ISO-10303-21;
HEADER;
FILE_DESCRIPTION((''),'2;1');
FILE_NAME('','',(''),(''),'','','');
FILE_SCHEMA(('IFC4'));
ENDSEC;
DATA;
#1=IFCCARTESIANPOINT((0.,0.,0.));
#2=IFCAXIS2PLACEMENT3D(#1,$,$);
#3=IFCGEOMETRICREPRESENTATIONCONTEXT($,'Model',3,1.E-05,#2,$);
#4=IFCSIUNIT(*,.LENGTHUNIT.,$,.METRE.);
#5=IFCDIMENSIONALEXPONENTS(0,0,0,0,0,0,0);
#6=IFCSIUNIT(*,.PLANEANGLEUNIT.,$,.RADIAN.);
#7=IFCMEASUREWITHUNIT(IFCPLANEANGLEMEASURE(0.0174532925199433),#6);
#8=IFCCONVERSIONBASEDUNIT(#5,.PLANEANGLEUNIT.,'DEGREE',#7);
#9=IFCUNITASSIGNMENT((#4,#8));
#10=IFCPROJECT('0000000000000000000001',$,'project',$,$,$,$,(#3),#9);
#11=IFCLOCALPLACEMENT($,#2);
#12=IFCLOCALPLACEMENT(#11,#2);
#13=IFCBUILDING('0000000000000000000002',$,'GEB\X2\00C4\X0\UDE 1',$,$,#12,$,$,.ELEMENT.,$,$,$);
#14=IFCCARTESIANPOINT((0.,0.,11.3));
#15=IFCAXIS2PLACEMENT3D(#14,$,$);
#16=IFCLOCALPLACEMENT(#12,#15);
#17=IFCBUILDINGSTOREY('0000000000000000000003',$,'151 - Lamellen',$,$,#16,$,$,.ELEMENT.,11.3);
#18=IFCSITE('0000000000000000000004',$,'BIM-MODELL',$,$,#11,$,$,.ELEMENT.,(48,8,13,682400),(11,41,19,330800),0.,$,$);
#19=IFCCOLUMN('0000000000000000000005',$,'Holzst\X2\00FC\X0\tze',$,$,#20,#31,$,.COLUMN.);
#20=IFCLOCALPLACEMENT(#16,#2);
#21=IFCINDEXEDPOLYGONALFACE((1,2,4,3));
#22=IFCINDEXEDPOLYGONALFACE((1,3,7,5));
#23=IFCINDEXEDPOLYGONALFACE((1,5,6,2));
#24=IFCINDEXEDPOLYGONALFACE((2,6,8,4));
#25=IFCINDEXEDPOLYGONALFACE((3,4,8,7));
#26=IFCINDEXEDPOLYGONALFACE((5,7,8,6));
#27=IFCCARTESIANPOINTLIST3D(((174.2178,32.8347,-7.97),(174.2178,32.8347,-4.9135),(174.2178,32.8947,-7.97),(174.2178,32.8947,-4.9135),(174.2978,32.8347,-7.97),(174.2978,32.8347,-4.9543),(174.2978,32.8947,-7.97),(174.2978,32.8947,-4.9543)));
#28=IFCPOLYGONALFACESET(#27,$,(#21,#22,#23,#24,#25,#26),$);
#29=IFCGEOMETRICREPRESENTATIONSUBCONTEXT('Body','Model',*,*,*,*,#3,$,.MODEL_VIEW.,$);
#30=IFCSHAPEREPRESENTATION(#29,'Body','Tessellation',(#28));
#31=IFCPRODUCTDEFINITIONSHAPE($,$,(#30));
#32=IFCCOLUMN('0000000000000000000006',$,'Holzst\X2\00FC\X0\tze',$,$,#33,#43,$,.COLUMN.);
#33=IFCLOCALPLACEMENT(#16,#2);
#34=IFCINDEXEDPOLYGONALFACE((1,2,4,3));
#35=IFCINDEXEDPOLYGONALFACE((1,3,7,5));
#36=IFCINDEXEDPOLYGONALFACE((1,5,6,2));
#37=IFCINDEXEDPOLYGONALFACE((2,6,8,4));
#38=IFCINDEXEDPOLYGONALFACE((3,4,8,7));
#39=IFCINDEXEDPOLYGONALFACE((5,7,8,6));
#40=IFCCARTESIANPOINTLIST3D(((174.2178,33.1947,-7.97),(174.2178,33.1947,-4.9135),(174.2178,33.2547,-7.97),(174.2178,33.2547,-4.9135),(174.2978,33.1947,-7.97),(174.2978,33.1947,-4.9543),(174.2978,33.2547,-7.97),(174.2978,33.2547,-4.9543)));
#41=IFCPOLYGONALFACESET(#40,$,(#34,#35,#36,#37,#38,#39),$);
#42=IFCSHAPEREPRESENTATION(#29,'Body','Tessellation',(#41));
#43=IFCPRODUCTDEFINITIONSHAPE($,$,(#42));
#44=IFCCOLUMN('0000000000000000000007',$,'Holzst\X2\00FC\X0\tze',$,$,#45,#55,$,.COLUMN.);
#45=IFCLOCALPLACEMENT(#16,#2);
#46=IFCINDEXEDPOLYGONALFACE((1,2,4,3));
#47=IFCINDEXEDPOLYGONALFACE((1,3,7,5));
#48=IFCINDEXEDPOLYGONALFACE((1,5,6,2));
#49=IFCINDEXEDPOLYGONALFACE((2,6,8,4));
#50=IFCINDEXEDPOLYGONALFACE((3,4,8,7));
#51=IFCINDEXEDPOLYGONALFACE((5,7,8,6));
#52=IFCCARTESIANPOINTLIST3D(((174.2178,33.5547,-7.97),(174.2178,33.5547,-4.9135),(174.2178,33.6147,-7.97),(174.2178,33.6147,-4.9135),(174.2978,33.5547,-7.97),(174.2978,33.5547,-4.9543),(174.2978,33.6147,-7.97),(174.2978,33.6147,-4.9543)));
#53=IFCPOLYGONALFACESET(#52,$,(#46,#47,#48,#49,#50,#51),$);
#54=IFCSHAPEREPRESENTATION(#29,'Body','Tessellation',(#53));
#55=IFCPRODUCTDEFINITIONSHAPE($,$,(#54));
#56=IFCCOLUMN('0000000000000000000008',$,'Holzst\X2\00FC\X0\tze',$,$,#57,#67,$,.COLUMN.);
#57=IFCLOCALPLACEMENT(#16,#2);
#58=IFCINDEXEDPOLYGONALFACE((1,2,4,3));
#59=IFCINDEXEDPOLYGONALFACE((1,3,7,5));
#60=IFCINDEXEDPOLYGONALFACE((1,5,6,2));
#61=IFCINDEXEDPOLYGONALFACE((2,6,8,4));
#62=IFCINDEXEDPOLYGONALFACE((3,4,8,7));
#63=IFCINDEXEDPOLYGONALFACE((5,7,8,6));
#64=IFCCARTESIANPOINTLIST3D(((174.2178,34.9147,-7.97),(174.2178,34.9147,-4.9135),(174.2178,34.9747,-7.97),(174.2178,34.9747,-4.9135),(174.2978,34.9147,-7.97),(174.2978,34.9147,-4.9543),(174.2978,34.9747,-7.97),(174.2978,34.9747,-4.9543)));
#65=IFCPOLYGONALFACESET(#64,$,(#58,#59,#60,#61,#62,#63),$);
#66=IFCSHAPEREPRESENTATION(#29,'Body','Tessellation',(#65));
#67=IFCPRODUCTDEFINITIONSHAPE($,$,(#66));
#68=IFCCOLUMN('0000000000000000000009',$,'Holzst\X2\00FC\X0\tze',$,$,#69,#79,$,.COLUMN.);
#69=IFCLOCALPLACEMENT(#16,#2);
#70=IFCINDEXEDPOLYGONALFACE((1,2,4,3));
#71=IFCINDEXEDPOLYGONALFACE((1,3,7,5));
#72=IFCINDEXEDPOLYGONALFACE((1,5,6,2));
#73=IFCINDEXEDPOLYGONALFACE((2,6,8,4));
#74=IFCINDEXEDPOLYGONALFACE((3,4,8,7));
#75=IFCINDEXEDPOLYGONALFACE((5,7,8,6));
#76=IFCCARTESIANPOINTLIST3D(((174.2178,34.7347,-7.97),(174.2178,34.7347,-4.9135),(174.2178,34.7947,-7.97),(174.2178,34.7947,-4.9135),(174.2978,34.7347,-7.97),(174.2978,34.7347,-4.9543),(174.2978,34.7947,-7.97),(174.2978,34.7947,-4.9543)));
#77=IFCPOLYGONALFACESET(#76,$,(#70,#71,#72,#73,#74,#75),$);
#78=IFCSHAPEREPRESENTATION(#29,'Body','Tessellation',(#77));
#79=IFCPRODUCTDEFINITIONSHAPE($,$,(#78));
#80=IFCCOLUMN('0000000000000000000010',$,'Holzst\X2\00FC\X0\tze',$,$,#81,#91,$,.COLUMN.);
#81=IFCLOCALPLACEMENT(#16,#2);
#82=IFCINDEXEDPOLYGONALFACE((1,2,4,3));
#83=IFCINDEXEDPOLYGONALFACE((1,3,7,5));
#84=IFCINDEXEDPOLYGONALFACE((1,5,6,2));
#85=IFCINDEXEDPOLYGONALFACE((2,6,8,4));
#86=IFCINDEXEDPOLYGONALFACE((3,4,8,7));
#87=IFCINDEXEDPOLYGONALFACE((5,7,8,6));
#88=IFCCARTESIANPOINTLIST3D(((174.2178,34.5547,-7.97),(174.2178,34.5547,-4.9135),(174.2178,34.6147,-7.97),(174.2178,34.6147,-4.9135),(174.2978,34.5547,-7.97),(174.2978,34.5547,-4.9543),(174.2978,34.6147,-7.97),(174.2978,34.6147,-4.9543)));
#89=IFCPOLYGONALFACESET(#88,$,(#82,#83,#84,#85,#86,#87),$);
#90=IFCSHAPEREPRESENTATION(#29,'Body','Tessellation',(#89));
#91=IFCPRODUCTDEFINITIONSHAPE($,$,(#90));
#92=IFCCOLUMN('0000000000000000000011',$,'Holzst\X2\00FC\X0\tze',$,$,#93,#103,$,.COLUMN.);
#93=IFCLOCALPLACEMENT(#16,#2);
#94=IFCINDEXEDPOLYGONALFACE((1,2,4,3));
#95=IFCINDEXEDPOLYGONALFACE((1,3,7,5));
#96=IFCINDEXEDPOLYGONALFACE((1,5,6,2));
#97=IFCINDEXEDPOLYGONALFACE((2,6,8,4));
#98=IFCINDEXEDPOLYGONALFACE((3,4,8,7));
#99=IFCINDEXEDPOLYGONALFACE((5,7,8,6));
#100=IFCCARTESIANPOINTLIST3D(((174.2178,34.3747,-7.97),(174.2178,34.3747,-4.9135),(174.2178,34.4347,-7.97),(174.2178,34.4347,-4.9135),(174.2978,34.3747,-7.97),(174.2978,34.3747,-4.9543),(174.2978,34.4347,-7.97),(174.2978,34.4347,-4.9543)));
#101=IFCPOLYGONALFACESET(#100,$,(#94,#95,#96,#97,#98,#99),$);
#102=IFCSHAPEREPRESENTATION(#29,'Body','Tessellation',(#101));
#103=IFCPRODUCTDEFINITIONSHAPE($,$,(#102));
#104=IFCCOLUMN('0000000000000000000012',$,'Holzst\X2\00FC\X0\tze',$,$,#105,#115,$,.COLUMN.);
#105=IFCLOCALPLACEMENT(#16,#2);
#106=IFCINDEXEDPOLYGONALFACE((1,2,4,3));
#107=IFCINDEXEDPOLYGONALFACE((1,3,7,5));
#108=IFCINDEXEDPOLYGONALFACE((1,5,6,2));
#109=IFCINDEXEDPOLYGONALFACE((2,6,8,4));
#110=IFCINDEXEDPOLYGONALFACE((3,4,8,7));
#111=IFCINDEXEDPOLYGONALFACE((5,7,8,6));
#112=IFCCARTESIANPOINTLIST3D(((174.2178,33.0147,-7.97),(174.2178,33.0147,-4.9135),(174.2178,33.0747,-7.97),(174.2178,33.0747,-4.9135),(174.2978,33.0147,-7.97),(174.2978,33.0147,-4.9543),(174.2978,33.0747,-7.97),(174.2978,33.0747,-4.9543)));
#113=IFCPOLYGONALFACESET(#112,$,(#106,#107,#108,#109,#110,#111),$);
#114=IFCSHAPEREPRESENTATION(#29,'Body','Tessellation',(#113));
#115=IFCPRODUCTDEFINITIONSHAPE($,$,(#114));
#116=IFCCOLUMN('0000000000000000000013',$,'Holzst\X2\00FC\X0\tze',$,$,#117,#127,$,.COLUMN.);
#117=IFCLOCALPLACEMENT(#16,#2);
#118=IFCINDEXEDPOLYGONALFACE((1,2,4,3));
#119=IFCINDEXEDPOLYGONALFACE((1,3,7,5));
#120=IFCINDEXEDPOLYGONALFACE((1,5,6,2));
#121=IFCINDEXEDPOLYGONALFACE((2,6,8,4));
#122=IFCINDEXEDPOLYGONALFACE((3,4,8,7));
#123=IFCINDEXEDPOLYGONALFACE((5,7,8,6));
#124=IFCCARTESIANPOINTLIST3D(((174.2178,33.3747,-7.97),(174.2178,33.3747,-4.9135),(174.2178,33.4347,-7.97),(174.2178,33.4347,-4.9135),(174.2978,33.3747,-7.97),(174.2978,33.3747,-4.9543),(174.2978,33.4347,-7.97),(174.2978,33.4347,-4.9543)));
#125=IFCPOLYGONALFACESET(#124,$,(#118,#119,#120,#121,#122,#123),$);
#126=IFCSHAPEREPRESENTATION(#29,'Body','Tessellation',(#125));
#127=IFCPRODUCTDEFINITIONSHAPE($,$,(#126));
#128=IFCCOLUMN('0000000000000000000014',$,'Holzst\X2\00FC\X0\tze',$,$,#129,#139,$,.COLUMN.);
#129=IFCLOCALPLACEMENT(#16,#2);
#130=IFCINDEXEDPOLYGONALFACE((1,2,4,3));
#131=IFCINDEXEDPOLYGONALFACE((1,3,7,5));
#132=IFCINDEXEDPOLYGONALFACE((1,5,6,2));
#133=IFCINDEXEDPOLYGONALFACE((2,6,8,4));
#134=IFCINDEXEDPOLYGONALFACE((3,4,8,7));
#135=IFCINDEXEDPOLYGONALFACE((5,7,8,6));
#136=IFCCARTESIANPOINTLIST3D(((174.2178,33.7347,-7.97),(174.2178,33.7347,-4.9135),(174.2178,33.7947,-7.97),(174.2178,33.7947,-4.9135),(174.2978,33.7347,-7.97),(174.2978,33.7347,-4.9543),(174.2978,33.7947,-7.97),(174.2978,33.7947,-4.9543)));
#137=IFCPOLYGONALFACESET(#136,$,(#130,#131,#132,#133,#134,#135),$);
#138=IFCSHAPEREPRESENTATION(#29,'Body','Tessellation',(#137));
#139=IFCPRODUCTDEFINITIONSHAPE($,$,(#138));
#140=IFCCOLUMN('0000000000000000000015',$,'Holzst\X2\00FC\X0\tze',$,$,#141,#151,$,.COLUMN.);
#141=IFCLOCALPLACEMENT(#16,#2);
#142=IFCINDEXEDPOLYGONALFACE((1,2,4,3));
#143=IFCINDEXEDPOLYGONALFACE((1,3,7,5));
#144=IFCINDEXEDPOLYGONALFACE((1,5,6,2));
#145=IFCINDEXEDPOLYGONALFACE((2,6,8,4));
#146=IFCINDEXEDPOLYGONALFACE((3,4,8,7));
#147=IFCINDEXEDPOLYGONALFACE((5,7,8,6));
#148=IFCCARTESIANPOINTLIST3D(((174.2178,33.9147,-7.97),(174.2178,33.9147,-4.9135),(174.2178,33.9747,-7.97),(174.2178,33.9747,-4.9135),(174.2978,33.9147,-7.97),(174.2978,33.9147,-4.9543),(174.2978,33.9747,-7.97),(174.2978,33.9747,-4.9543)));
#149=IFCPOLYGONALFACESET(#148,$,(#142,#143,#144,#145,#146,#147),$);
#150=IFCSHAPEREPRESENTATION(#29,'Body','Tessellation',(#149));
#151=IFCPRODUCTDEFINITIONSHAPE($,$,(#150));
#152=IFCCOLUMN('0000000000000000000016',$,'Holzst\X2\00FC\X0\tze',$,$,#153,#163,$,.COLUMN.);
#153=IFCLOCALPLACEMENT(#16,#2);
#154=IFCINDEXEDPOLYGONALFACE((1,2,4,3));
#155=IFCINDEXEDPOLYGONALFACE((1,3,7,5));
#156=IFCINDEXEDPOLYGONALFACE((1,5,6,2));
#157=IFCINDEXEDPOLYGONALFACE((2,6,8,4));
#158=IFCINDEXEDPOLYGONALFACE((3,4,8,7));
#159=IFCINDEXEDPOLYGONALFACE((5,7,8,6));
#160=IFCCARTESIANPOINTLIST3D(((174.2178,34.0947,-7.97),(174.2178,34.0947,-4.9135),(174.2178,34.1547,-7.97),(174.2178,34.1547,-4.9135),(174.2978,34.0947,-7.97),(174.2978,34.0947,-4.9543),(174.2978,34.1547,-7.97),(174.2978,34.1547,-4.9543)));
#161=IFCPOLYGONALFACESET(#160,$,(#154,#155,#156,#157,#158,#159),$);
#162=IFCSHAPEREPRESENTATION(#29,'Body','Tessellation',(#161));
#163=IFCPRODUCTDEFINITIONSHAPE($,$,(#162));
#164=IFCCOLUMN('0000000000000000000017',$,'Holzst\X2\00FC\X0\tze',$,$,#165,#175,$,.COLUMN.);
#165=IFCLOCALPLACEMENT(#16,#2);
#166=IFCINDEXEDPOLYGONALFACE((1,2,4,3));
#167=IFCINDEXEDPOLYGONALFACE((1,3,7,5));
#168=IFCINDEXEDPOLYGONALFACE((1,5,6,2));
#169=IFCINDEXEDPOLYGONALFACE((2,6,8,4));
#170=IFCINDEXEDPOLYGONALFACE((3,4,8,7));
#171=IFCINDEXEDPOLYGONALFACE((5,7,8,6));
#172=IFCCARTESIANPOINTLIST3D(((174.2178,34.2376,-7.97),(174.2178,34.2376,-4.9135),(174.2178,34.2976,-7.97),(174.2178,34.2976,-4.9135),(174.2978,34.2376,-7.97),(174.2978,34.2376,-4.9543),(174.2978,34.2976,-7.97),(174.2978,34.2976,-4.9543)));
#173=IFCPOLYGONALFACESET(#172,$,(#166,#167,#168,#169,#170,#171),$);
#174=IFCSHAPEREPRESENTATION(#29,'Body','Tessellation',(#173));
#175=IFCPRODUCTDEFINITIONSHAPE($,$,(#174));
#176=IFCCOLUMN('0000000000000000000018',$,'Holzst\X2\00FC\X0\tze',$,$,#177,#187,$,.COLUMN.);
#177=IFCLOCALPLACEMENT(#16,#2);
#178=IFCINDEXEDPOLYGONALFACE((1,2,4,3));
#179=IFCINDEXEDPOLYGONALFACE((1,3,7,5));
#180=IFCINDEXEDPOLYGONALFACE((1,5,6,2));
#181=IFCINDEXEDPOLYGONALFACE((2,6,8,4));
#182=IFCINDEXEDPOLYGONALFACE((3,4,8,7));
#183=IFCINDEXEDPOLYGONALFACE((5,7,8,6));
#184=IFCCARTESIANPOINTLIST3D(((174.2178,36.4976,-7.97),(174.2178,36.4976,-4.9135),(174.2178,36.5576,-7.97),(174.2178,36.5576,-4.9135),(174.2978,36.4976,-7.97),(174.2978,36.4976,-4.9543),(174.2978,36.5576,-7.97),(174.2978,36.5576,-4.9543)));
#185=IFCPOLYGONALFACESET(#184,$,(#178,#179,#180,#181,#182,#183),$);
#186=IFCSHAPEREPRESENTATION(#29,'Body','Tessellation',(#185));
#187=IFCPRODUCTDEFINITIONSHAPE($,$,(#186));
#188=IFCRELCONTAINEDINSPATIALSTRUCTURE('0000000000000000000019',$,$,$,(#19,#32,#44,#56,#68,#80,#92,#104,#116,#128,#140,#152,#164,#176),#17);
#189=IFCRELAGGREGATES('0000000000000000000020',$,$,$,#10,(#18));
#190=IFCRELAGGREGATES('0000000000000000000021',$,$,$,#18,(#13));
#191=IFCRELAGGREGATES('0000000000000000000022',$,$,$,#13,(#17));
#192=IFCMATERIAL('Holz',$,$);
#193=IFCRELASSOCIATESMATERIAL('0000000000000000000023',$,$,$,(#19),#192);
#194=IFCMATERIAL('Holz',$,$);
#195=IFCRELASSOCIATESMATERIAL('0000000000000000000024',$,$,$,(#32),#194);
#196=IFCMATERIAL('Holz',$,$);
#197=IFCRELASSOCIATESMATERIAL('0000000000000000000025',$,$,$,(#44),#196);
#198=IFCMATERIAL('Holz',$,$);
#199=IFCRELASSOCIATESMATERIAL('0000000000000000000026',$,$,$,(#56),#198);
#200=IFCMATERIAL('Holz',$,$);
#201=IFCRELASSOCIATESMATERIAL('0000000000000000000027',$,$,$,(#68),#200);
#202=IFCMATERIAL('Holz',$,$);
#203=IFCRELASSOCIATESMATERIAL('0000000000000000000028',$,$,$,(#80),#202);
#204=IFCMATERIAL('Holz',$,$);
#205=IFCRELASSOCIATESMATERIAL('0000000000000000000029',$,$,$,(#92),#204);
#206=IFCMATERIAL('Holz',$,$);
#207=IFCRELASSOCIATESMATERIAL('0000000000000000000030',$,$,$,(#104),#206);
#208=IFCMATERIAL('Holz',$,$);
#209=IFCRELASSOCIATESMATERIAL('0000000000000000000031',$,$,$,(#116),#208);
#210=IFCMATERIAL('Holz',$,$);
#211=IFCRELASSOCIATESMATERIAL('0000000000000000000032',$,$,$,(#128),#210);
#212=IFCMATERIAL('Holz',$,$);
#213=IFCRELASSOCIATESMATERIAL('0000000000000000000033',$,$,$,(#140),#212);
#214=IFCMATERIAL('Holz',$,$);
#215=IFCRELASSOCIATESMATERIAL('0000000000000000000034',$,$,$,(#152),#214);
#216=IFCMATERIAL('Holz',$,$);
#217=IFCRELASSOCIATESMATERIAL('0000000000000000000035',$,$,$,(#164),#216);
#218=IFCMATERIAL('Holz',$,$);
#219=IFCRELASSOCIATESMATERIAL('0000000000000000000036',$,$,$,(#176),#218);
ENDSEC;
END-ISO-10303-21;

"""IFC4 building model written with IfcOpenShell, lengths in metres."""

from ifc_helpers import new_model, entity, si_unit, converted_unit, frame, frame_2d, origin, origin_with_axes, place, context, subcontext, project, spatial, rectangle, extrude, clip, halfspace, material, element, save


model = new_model("IFC4")

# Units and contexts
model_context = context("Model", 3, precision=1e-05, world=origin())
body_context = subcontext(model_context, "Body", "Model", "MODEL_VIEW")
ifc_project = project(units=[si_unit("LENGTHUNIT", "METRE"), converted_unit("PLANEANGLEUNIT", "DEGREE", entity("IfcPlaneAngleMeasure", 0.0174532925199433), si_unit("PLANEANGLEUNIT", "RADIAN"), dimensions=[0, 0, 0, 0, 0, 0, 0])], contexts=[model_context])

# Site, building, storey
site_placement = place(None, origin())
site = spatial("IfcSite", under=ifc_project, at=site_placement, Name="BIM-MODELL", CompositionType="ELEMENT", RefLatitude=(48, 8, 13, 682400), RefLongitude=(11, 41, 19, 330800), RefElevation=0.0)
building_placement = place(site_placement, origin())
building = spatial("IfcBuilding", under=site, at=building_placement, Name="GEBÄUDE 1", CompositionType="ELEMENT")
storey_placement = place(building_placement, frame((0.0, 0.0, 11.3)))
storey = spatial("IfcBuildingStorey", under=building, at=storey_placement, Name="151 - Lamellen", CompositionType="ELEMENT", Elevation=11.3)

# Columns
ifc_material_1 = material(Name="Holz")
column_1_placement = place(storey_placement, frame((174.2978, 32.8347, -7.97)))
element("IfcColumn", 1, at=column_1_placement, inside=storey, material=ifc_material_1, Name="Holzstütze", PredefinedType="COLUMN", context=body_context, shape_type="Clipping", body=[
    clip(extrude(rectangle(XDim=0.06, YDim=0.08, at=frame_2d((-0.04, 0.03), x_axis=(0.0, 1.0))), origin_with_axes(), (0.0, 0.0, 1.0), 3.0565), halfspace(frame((-0.04, 0.03, 3.0361), z_axis=(-0.45399, 0.0, -0.891007), x_axis=(0.891007, 0.0, -0.45399)), True)),
])
ifc_material_2 = material(Name="Holz")
column_2_placement = place(storey_placement, frame((174.2978, 33.1947, -7.97)))
element("IfcColumn", 2, at=column_2_placement, inside=storey, material=ifc_material_2, Name="Holzstütze", PredefinedType="COLUMN", context=body_context, shape_type="Clipping", body=[
    clip(extrude(rectangle(XDim=0.06, YDim=0.08, at=frame_2d((-0.04, 0.03), x_axis=(0.0, 1.0))), origin_with_axes(), (0.0, 0.0, 1.0), 3.0565), halfspace(frame((-0.04, 0.03, 3.0361), z_axis=(-0.45399, 0.0, -0.891007), x_axis=(0.891007, 0.0, -0.45399)), True)),
])
ifc_material_3 = material(Name="Holz")
column_3_placement = place(storey_placement, frame((174.2978, 33.5547, -7.97)))
element("IfcColumn", 3, at=column_3_placement, inside=storey, material=ifc_material_3, Name="Holzstütze", PredefinedType="COLUMN", context=body_context, shape_type="Clipping", body=[
    clip(extrude(rectangle(XDim=0.06, YDim=0.08, at=frame_2d((-0.04, 0.03), x_axis=(0.0, 1.0))), origin_with_axes(), (0.0, 0.0, 1.0), 3.0565), halfspace(frame((-0.04, 0.03, 3.0361), z_axis=(-0.45399, 0.0, -0.891007), x_axis=(0.891007, 0.0, -0.45399)), True)),
])
ifc_material_4 = material(Name="Holz")
column_4_placement = place(storey_placement, frame((174.2978, 34.9147, -7.97)))
element("IfcColumn", 4, at=column_4_placement, inside=storey, material=ifc_material_4, Name="Holzstütze", PredefinedType="COLUMN", context=body_context, shape_type="Clipping", body=[
    clip(extrude(rectangle(XDim=0.06, YDim=0.08, at=frame_2d((-0.04, 0.03), x_axis=(0.0, 1.0))), origin_with_axes(), (0.0, 0.0, 1.0), 3.0565), halfspace(frame((-0.04, 0.03, 3.0361), z_axis=(-0.45399, 0.0, -0.891007), x_axis=(0.891007, 0.0, -0.45399)), True)),
])
ifc_material_5 = material(Name="Holz")
column_5_placement = place(storey_placement, frame((174.2978, 34.7347, -7.97)))
element("IfcColumn", 5, at=column_5_placement, inside=storey, material=ifc_material_5, Name="Holzstütze", PredefinedType="COLUMN", context=body_context, shape_type="Clipping", body=[
    clip(extrude(rectangle(XDim=0.06, YDim=0.08, at=frame_2d((-0.04, 0.03), x_axis=(0.0, 1.0))), origin_with_axes(), (0.0, 0.0, 1.0), 3.0565), halfspace(frame((-0.04, 0.03, 3.0361), z_axis=(-0.45399, 0.0, -0.891007), x_axis=(0.891007, 0.0, -0.45399)), True)),
])
ifc_material_6 = material(Name="Holz")
column_6_placement = place(storey_placement, frame((174.2978, 34.5547, -7.97)))
element("IfcColumn", 6, at=column_6_placement, inside=storey, material=ifc_material_6, Name="Holzstütze", PredefinedType="COLUMN", context=body_context, shape_type="Clipping", body=[
    clip(extrude(rectangle(XDim=0.06, YDim=0.08, at=frame_2d((-0.04, 0.03), x_axis=(0.0, 1.0))), origin_with_axes(), (0.0, 0.0, 1.0), 3.0565), halfspace(frame((-0.04, 0.03, 3.0361), z_axis=(-0.45399, 0.0, -0.891007), x_axis=(0.891007, 0.0, -0.45399)), True)),
])
ifc_material_7 = material(Name="Holz")
column_7_placement = place(storey_placement, frame((174.2978, 34.3747, -7.97)))
element("IfcColumn", 7, at=column_7_placement, inside=storey, material=ifc_material_7, Name="Holzstütze", PredefinedType="COLUMN", context=body_context, shape_type="Clipping", body=[
    clip(extrude(rectangle(XDim=0.06, YDim=0.08, at=frame_2d((-0.04, 0.03), x_axis=(0.0, 1.0))), origin_with_axes(), (0.0, 0.0, 1.0), 3.0565), halfspace(frame((-0.04, 0.03, 3.0361), z_axis=(-0.45399, 0.0, -0.891007), x_axis=(0.891007, 0.0, -0.45399)), True)),
])
ifc_material_8 = material(Name="Holz")
column_8_placement = place(storey_placement, frame((174.2978, 33.0147, -7.97)))
element("IfcColumn", 8, at=column_8_placement, inside=storey, material=ifc_material_8, Name="Holzstütze", PredefinedType="COLUMN", context=body_context, shape_type="Clipping", body=[
    clip(extrude(rectangle(XDim=0.06, YDim=0.08, at=frame_2d((-0.04, 0.03), x_axis=(0.0, 1.0))), origin_with_axes(), (0.0, 0.0, 1.0), 3.0565), halfspace(frame((-0.04, 0.03, 3.0361), z_axis=(-0.45399, 0.0, -0.891007), x_axis=(0.891007, 0.0, -0.45399)), True)),
])
ifc_material_9 = material(Name="Holz")
column_9_placement = place(storey_placement, frame((174.2978, 33.3747, -7.97)))
element("IfcColumn", 9, at=column_9_placement, inside=storey, material=ifc_material_9, Name="Holzstütze", PredefinedType="COLUMN", context=body_context, shape_type="Clipping", body=[
    clip(extrude(rectangle(XDim=0.06, YDim=0.08, at=frame_2d((-0.04, 0.03), x_axis=(0.0, 1.0))), origin_with_axes(), (0.0, 0.0, 1.0), 3.0565), halfspace(frame((-0.04, 0.03, 3.0361), z_axis=(-0.45399, 0.0, -0.891007), x_axis=(0.891007, 0.0, -0.45399)), True)),
])
ifc_material_10 = material(Name="Holz")
column_10_placement = place(storey_placement, frame((174.2978, 33.7347, -7.97)))
element("IfcColumn", 10, at=column_10_placement, inside=storey, material=ifc_material_10, Name="Holzstütze", PredefinedType="COLUMN", context=body_context, shape_type="Clipping", body=[
    clip(extrude(rectangle(XDim=0.06, YDim=0.08, at=frame_2d((-0.04, 0.03), x_axis=(0.0, 1.0))), origin_with_axes(), (0.0, 0.0, 1.0), 3.0565), halfspace(frame((-0.04, 0.03, 3.0361), z_axis=(-0.45399, 0.0, -0.891007), x_axis=(0.891007, 0.0, -0.45399)), True)),
])
ifc_material_11 = material(Name="Holz")
column_11_placement = place(storey_placement, frame((174.2978, 33.9147, -7.97)))
element("IfcColumn", 11, at=column_11_placement, inside=storey, material=ifc_material_11, Name="Holzstütze", PredefinedType="COLUMN", context=body_context, shape_type="Clipping", body=[
    clip(extrude(rectangle(XDim=0.06, YDim=0.08, at=frame_2d((-0.04, 0.03), x_axis=(0.0, 1.0))), origin_with_axes(), (0.0, 0.0, 1.0), 3.0565), halfspace(frame((-0.04, 0.03, 3.0361), z_axis=(-0.45399, 0.0, -0.891007), x_axis=(0.891007, 0.0, -0.45399)), True)),
])
ifc_material_12 = material(Name="Holz")
column_12_placement = place(storey_placement, frame((174.2978, 34.0947, -7.97)))
element("IfcColumn", 12, at=column_12_placement, inside=storey, material=ifc_material_12, Name="Holzstütze", PredefinedType="COLUMN", context=body_context, shape_type="Clipping", body=[
    clip(extrude(rectangle(XDim=0.06, YDim=0.08, at=frame_2d((-0.04, 0.03), x_axis=(0.0, 1.0))), origin_with_axes(), (0.0, 0.0, 1.0), 3.0565), halfspace(frame((-0.04, 0.03, 3.0361), z_axis=(-0.45399, 0.0, -0.891007), x_axis=(0.891007, 0.0, -0.45399)), True)),
])
ifc_material_13 = material(Name="Holz")
column_13_placement = place(storey_placement, frame((174.2978, 34.2376, -7.97)))
element("IfcColumn", 13, at=column_13_placement, inside=storey, material=ifc_material_13, Name="Holzstütze", PredefinedType="COLUMN", context=body_context, shape_type="Clipping", body=[
    clip(extrude(rectangle(XDim=0.06, YDim=0.08, at=frame_2d((-0.04, 0.03), x_axis=(0.0, 1.0))), origin_with_axes(), (0.0, 0.0, 1.0), 3.0565), halfspace(frame((-0.04, 0.03, 3.0361), z_axis=(-0.45399, 0.0, -0.891007), x_axis=(0.891007, 0.0, -0.45399)), True)),
])
ifc_material_14 = material(Name="Holz")
column_14_placement = place(storey_placement, frame((174.2978, 36.4976, -7.97)))
element("IfcColumn", 14, at=column_14_placement, inside=storey, material=ifc_material_14, Name="Holzstütze", PredefinedType="COLUMN", context=body_context, shape_type="Clipping", body=[
    clip(extrude(rectangle(XDim=0.06, YDim=0.08, at=frame_2d((-0.04, 0.03), x_axis=(0.0, 1.0))), origin_with_axes(), (0.0, 0.0, 1.0), 3.0565), halfspace(frame((-0.04, 0.03, 3.0361), z_axis=(-0.45399, 0.0, -0.891007), x_axis=(0.891007, 0.0, -0.45399)), True)),
])

save(model, "model.ifc")
